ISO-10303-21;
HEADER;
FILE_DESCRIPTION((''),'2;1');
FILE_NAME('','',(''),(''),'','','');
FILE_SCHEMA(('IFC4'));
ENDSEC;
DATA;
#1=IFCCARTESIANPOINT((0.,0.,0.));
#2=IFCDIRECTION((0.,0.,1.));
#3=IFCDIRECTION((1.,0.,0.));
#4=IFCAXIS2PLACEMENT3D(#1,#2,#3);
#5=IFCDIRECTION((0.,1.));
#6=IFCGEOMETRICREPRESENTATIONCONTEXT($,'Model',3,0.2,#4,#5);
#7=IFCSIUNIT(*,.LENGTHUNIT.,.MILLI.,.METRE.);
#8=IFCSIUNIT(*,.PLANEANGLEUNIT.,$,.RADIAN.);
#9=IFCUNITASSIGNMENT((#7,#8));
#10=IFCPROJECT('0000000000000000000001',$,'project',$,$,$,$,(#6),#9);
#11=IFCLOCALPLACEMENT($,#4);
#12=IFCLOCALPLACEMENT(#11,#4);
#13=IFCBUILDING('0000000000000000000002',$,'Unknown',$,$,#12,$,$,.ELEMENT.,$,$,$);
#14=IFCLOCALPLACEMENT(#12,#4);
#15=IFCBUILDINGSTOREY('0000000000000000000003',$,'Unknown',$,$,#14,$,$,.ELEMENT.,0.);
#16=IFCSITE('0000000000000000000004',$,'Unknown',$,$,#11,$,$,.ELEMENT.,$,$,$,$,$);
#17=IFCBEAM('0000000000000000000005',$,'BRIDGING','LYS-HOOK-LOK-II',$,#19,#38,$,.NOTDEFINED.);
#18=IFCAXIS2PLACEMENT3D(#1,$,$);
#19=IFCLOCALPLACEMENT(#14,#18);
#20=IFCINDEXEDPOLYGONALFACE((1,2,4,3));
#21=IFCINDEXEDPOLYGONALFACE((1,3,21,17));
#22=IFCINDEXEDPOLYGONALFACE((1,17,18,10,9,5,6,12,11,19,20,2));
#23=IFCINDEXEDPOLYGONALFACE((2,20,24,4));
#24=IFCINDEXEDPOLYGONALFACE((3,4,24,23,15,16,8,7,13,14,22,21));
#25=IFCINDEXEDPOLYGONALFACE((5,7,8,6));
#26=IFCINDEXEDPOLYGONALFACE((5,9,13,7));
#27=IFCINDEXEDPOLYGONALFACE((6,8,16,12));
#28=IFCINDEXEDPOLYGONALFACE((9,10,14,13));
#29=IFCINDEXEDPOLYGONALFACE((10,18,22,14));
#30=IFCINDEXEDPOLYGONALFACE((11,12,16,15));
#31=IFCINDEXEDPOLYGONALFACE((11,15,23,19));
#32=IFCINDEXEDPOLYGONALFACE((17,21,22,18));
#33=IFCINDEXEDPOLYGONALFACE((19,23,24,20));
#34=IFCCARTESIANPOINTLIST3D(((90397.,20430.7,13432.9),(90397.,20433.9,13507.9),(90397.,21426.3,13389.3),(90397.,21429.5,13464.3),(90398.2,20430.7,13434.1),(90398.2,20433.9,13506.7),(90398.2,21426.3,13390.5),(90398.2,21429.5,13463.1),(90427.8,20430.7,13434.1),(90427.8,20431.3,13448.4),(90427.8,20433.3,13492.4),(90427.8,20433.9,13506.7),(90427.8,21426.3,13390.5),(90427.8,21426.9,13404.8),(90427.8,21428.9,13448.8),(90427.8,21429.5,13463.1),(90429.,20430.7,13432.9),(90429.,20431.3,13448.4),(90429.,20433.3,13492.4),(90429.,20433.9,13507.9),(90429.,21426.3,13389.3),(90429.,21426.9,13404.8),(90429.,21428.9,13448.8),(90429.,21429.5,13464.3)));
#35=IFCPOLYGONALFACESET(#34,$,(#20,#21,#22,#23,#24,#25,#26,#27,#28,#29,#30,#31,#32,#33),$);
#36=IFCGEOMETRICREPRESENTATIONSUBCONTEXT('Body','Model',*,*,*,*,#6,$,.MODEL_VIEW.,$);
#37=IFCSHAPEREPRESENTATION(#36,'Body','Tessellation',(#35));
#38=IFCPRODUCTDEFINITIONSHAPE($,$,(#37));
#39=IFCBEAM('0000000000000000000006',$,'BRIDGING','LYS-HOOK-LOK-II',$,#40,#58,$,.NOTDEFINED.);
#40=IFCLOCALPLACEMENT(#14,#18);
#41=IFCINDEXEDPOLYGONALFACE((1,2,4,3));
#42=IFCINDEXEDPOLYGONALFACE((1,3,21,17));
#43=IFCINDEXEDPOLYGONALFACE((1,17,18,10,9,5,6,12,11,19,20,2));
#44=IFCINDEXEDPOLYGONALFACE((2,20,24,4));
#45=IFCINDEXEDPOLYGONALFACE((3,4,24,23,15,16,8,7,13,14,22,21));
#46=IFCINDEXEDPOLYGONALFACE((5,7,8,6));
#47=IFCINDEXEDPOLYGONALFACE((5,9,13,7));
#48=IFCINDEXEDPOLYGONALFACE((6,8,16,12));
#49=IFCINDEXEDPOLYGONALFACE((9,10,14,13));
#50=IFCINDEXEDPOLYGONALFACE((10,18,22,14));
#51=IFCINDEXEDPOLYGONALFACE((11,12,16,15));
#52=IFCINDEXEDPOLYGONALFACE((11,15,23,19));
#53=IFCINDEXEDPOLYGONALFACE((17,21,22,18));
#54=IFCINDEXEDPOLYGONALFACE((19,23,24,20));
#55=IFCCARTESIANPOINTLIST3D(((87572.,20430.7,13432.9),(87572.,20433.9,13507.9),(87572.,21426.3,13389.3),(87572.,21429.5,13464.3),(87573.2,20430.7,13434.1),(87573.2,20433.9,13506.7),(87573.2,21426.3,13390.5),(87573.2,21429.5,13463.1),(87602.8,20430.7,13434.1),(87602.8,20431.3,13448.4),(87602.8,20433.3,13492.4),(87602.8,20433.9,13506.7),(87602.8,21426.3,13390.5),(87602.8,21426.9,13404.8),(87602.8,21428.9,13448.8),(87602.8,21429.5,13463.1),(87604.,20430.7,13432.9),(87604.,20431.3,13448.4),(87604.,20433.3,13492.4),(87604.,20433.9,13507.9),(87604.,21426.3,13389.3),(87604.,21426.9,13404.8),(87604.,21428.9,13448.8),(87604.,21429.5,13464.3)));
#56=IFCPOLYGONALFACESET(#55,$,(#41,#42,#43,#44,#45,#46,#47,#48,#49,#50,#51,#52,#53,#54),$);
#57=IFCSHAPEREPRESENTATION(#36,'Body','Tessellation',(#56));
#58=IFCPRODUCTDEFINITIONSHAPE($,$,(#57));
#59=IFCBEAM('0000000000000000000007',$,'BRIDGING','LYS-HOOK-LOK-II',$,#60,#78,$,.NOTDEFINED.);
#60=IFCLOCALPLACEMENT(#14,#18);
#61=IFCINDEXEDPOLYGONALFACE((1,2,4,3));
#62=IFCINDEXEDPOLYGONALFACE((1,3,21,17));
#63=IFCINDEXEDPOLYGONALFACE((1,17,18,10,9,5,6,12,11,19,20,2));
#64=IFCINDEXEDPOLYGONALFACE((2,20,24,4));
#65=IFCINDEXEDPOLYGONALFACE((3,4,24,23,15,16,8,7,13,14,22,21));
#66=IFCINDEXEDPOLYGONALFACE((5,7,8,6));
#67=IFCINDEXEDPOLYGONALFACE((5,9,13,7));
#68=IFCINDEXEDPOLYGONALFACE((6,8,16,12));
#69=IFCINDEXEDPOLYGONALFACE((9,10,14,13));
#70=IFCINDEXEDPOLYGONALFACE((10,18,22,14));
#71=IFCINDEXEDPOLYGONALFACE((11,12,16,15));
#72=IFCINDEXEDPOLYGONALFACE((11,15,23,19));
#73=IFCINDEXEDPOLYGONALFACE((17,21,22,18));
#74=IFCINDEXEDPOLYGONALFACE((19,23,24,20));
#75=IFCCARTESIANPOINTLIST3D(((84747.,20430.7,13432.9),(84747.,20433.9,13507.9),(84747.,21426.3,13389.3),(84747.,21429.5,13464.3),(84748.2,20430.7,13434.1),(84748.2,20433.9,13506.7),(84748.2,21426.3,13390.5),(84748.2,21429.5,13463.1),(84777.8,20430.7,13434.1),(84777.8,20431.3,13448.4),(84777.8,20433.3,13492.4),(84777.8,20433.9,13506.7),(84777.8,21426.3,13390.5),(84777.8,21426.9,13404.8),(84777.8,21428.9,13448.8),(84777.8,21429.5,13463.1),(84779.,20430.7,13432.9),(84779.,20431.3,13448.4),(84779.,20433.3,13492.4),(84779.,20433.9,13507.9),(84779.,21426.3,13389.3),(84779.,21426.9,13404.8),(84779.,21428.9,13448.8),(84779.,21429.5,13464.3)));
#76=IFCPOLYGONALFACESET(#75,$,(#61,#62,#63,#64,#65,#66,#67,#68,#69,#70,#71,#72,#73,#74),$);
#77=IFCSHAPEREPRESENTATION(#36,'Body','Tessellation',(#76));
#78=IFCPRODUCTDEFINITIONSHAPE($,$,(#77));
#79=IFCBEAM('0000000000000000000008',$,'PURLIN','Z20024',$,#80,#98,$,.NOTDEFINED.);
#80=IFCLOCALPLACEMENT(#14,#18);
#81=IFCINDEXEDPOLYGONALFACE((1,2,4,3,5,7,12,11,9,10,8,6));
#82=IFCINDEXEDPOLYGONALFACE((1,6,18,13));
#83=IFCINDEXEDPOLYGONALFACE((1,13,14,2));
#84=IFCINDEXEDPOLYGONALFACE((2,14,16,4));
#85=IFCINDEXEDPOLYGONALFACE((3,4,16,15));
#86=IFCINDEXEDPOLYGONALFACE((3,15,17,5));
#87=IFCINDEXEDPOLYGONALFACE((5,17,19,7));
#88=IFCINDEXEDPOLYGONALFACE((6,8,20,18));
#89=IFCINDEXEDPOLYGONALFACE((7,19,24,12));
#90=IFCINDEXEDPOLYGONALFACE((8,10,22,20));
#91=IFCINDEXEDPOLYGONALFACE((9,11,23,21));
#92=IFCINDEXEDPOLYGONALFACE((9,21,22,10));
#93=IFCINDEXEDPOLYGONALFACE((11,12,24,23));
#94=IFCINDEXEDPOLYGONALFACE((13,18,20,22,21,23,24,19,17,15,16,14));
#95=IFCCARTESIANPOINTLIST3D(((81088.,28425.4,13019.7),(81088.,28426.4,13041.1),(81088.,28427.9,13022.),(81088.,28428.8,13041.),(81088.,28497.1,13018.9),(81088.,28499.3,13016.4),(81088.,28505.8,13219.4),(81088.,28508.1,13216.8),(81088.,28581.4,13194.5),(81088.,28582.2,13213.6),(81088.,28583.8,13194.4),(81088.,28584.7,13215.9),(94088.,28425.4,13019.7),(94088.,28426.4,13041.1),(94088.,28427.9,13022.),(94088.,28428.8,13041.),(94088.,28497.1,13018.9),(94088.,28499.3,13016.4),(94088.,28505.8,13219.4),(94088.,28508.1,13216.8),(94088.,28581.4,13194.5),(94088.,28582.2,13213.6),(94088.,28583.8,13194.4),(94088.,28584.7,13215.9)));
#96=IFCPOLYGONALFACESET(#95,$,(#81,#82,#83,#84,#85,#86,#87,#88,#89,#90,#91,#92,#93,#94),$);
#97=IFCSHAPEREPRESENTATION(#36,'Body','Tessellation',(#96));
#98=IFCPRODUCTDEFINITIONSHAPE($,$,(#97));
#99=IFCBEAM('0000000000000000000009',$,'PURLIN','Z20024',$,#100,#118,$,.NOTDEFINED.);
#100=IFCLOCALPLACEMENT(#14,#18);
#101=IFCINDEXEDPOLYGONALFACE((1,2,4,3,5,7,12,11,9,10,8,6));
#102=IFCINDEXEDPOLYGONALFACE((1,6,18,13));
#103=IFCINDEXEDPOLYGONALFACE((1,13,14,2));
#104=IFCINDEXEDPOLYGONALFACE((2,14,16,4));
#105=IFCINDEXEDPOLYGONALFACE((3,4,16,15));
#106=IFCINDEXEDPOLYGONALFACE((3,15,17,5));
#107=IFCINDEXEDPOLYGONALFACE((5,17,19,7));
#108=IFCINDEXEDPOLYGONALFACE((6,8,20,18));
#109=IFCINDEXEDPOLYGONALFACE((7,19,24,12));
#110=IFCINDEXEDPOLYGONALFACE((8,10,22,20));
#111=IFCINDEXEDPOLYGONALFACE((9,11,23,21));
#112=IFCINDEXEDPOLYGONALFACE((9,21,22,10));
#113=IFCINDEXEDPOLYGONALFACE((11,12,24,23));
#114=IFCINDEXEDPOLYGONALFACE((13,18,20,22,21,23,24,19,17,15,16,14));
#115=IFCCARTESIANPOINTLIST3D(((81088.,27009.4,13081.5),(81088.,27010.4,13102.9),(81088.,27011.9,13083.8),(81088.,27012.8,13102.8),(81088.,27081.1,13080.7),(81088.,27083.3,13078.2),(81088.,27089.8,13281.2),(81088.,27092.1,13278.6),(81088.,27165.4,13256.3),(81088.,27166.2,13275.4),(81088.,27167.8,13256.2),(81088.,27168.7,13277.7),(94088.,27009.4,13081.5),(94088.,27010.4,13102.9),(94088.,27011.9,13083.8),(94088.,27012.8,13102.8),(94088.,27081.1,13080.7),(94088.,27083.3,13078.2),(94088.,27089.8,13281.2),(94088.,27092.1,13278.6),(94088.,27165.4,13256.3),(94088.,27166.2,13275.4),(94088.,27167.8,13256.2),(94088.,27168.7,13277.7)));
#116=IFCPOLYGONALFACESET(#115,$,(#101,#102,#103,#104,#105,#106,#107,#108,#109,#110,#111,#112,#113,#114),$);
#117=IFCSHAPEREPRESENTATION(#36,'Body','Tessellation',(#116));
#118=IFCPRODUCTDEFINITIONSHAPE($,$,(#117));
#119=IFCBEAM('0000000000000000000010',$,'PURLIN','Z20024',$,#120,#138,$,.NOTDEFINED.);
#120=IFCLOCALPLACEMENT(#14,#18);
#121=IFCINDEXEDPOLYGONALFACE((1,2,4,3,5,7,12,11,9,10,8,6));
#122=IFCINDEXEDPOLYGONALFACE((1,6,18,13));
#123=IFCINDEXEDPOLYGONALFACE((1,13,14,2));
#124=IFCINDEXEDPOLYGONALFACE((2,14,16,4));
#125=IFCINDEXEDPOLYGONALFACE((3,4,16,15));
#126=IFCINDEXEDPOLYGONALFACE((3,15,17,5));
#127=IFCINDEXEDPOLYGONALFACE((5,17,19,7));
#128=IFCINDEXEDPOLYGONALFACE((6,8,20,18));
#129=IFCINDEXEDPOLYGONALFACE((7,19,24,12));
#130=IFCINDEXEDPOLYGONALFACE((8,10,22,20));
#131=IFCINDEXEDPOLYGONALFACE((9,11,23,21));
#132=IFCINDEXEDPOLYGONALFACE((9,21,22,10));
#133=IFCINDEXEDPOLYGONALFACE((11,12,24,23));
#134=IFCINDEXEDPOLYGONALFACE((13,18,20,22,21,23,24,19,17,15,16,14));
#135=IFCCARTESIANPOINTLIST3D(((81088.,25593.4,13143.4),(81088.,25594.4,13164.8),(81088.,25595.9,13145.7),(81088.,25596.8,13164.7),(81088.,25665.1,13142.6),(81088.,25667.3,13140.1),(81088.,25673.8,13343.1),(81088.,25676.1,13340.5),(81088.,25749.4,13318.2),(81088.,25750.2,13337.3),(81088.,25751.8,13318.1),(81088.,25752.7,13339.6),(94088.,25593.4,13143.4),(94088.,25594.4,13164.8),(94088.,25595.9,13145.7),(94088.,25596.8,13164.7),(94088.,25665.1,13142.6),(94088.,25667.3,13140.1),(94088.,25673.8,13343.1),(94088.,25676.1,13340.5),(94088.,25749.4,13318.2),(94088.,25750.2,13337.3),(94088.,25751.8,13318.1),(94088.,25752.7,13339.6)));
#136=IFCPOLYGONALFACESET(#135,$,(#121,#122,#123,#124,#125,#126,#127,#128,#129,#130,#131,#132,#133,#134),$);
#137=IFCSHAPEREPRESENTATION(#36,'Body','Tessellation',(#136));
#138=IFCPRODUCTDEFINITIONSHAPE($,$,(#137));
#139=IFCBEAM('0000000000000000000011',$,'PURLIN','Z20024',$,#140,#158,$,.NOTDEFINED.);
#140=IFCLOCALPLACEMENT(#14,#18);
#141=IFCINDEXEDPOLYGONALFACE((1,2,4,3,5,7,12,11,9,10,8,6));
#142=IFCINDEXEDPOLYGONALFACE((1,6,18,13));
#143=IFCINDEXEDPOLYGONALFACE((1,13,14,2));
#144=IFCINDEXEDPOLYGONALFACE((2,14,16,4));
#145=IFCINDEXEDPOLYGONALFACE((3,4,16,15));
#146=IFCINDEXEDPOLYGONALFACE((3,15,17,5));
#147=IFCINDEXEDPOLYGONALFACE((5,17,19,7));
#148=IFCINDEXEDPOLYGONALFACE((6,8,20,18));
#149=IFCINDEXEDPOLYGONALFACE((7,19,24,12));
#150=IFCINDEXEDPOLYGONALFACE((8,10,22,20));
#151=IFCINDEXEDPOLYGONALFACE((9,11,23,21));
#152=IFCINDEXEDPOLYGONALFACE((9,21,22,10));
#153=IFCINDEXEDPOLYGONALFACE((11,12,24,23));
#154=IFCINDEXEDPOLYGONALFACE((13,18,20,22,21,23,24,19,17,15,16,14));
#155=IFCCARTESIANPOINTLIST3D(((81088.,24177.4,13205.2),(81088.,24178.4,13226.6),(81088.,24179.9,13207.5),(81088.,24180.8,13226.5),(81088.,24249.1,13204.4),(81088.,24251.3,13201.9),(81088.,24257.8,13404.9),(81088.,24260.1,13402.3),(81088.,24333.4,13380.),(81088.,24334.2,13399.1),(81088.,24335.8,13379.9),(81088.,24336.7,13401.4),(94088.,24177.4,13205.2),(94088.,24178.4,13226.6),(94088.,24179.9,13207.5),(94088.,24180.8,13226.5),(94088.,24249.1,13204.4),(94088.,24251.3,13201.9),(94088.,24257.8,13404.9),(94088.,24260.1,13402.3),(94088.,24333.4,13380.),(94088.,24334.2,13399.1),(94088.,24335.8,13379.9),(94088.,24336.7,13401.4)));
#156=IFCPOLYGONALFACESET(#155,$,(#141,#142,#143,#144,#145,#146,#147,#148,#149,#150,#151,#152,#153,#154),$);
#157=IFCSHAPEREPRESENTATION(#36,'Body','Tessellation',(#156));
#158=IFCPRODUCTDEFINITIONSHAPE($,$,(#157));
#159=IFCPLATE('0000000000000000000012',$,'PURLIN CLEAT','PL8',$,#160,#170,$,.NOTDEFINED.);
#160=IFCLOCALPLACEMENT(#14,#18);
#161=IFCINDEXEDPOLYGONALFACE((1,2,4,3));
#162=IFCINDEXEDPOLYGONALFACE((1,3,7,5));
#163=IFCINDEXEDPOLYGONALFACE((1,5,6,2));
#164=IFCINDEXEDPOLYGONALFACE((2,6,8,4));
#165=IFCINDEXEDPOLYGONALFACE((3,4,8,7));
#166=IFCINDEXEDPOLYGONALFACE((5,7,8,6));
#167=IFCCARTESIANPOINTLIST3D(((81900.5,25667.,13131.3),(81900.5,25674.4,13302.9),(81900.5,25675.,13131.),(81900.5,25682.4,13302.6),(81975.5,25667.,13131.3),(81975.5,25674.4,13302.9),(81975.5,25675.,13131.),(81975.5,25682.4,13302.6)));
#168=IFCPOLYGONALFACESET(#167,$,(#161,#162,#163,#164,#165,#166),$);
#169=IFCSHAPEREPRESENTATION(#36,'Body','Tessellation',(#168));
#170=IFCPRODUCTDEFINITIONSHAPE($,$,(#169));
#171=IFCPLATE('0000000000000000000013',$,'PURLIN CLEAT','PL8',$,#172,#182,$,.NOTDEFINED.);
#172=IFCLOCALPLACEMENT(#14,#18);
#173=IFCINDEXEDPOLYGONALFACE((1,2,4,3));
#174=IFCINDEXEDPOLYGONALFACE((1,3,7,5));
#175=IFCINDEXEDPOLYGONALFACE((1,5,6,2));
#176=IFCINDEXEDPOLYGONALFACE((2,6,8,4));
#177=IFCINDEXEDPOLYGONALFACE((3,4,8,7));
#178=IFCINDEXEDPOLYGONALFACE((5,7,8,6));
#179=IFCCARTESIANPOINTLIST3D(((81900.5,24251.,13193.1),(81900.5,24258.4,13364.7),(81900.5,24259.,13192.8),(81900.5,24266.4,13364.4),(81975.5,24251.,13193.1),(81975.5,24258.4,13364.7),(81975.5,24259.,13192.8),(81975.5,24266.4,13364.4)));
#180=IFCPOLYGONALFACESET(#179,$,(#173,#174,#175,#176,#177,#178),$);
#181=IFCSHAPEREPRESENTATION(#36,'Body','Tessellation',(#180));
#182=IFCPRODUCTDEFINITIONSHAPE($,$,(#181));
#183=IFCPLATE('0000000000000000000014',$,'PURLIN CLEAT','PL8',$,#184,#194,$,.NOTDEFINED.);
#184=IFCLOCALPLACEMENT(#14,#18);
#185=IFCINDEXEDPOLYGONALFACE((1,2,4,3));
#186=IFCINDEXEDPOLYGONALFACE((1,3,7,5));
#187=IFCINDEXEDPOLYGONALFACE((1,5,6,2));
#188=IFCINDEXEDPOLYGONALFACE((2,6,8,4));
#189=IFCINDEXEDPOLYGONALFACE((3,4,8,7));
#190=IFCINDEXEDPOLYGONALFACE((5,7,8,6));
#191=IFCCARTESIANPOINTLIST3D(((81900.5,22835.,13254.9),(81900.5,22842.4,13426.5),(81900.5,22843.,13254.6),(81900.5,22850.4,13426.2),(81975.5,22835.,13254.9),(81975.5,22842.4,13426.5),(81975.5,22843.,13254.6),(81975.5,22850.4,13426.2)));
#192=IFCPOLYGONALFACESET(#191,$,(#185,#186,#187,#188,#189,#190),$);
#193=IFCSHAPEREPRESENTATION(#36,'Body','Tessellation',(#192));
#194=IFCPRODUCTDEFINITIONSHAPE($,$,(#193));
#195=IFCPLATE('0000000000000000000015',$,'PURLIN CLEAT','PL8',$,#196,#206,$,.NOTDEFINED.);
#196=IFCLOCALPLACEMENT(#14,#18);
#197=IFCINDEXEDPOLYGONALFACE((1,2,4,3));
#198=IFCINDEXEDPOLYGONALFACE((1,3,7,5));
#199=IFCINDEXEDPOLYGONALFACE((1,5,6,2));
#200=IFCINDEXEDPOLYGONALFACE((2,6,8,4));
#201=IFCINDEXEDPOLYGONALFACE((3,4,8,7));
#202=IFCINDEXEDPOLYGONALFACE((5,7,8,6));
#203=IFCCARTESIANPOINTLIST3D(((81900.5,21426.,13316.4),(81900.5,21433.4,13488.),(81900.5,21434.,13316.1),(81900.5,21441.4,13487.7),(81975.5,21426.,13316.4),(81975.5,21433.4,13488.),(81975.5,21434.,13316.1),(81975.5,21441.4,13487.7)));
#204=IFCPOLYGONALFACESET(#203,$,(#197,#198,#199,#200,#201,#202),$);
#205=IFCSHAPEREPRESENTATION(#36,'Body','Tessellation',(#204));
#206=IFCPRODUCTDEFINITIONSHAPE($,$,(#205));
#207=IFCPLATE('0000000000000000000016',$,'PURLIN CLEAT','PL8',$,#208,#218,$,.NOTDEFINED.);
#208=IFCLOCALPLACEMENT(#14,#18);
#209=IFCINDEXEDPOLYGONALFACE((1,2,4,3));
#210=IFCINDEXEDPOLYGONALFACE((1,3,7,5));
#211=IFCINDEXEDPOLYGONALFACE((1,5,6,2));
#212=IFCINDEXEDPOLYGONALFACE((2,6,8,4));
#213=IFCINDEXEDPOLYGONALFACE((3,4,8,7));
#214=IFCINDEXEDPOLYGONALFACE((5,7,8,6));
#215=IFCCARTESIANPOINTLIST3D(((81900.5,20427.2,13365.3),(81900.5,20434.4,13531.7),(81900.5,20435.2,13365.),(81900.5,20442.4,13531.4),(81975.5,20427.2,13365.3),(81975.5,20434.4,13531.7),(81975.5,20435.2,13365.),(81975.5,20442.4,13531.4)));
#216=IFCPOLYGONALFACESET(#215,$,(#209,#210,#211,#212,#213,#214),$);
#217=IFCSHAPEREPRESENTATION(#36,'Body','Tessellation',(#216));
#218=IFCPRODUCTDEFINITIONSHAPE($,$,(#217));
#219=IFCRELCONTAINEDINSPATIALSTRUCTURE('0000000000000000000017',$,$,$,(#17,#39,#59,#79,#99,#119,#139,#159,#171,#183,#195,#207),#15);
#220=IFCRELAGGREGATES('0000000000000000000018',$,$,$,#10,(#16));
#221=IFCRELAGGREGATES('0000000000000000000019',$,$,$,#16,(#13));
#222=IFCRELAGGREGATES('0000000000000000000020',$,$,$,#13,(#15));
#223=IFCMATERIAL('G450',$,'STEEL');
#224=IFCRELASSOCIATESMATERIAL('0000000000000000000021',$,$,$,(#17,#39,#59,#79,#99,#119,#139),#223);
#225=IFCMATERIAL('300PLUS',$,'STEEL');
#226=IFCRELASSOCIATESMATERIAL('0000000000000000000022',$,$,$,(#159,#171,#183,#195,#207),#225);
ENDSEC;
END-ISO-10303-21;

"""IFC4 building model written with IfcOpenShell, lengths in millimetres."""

from ifc_helpers import new_model, si_unit, direction, frame, origin_with_axes, place, context, subcontext, project, spatial, line, indexed_curve, outline, extrude, material, element, save


model = new_model("IFC4")

# Units and contexts
model_context = context("Model", 3, precision=0.2, world=origin_with_axes(), true_north=direction((0.0, 1.0)))
body_context = subcontext(model_context, "Body", "Model", "MODEL_VIEW")
ifc_project = project(units=[si_unit("LENGTHUNIT", "METRE", prefix="MILLI"), si_unit("PLANEANGLEUNIT", "RADIAN")], contexts=[model_context])

# Site, building, storey
site_placement = place(None, origin_with_axes())
site = spatial("IfcSite", under=ifc_project, at=site_placement, Name="Unknown", CompositionType="ELEMENT")
building_placement = place(site_placement, origin_with_axes())
building = spatial("IfcBuilding", under=site, at=building_placement, Name="Unknown", CompositionType="ELEMENT")
storey_placement = place(building_placement, origin_with_axes())
storey = spatial("IfcBuildingStorey", under=building, at=storey_placement, Name="Unknown", CompositionType="ELEMENT", Elevation=0.0)

# Beams
ifc_material_1 = material(Name="G450", Category="STEEL")
for number, where, z_axis, x_axis, name in (
    (1, (90413.0, 20432.3, 13470.4), (1.0, 0.0, 0.0), (0.0, 0.999042, -0.043751), "BRIDGING"),
    (2, (87588.0, 20432.3, 13470.4), (1.0, 0.0, 0.0), (0.0, 0.999042, -0.043751), "BRIDGING"),
    (3, (84763.0, 20432.3, 13470.4), (1.0, 0.0, 0.0), (0.0, 0.999042, -0.043751), "BRIDGING"),
):
    element("IfcBeam", number, at=place(storey_placement, frame(where, z_axis=z_axis, x_axis=x_axis)), inside=storey, material=ifc_material_1, Name=name, Description="LYS-HOOK-LOK-II", PredefinedType="NOTDEFINED", context=body_context, shape_type="SolidModel", body=[
        extrude(outline(indexed_curve([(16.0, -37.5), (16.0, -22.0), (14.8, -22.0), (14.8, -36.3), (-14.8, -36.3), (-14.8, 36.3), (14.8, 36.3), (14.8, 22.0), (16.0, 22.0), (16.0, 37.5), (-16.0, 37.5), (-16.0, -37.5)], segments=[line(1, 2, 3, 4, 5, 6, 7, 8, 9, 10, 11, 12, 1)])), frame((0.0, 0.0, 0.0), z_axis=(-1.0, 0.0, 0.0), x_axis=(0.0, 0.0, 1.0)), (0.0, 0.0, -1.0), 996.6),
    ])
for number, where, z_axis, x_axis, name in (
    (4, (81088.0, 28502.6, 13117.9), (0.0, -0.999048, 0.043619), (1.0, 0.0, 0.0), "PURLIN"),
    (5, (81088.0, 27086.6, 13179.7), (0.0, -0.999048, 0.043619), (1.0, 0.0, 0.0), "PURLIN"),
    (6, (81088.0, 25670.6, 13241.6), (0.0, -0.999048, 0.043619), (1.0, 0.0, 0.0), "PURLIN"),
    (7, (81088.0, 24254.6, 13303.4), (0.0, -0.999048, 0.043619), (1.0, 0.0, 0.0), "PURLIN"),
):
    element("IfcBeam", number, at=place(storey_placement, frame(where, z_axis=z_axis, x_axis=x_axis)), inside=storey, material=ifc_material_1, Name=name, Description="Z20024", PredefinedType="NOTDEFINED", context=body_context, shape_type="SolidModel", body=[
        extrude(outline(indexed_curve([(72.8, -101.5), (72.8, -80.0), (70.4, -80.0), (70.4, -99.1), (1.2, -99.1), (1.2, 101.5), (-77.8, 101.5), (-77.8, 80.0), (-75.4, 80.0), (-75.4, 99.1), (-1.2, 99.1), (-1.2, -101.5)], segments=[line(1, 2, 3, 4, 5, 6, 7, 8, 9, 10, 11, 12, 1)])), frame((0.0, 0.0, 0.0), z_axis=(-1.0, 0.0, 0.0), x_axis=(0.0, 0.0, 1.0)), (0.0, 0.0, -1.0), 13000.0),
    ])

# Plates
ifc_material_2 = material(Name="300PLUS", Category="STEEL")
for number, where, z_axis, x_axis, name in (
    (8, (81900.5, 25671.0, 13131.2), (0.0, -0.999071, 0.043084), (1.0, 0.0, 0.0), "PURLIN CLEAT"),
    (9, (81900.5, 24255.0, 13193.0), (0.0, -0.999071, 0.043084), (1.0, 0.0, 0.0), "PURLIN CLEAT"),
    (10, (81900.5, 22839.0, 13254.8), (0.0, -0.999071, 0.043084), (1.0, 0.0, 0.0), "PURLIN CLEAT"),
    (11, (81900.5, 21430.0, 13316.3), (0.0, -0.999071, 0.043084), (1.0, 0.0, 0.0), "PURLIN CLEAT"),
):
    element("IfcPlate", number, at=place(storey_placement, frame(where, z_axis=z_axis, x_axis=x_axis)), inside=storey, material=ifc_material_2, Name=name, Description="PL8", PredefinedType="NOTDEFINED", context=body_context, shape_type="SolidModel", body=[
        extrude(outline(indexed_curve([(0.0, 0.0), (75.0, 0.0), (75.0, 171.8), (0.0, 171.8)], segments=[line(1, 2, 3, 4, 1)])), frame((0.0, 0.0, 4.0), z_axis=(0.0, 0.0, 1.0), x_axis=(1.0, 0.0, 0.0)), (0.0, 0.0, -1.0), 8.0),
    ])
plate_1_placement = place(storey_placement, frame((81900.5, 20431.2, 13365.2), z_axis=(0.0, -0.999065, 0.043229), x_axis=(1.0, 0.0, 0.0)))
element("IfcPlate", 12, at=plate_1_placement, inside=storey, material=ifc_material_2, Name="PURLIN CLEAT", Description="PL8", PredefinedType="NOTDEFINED", context=body_context, shape_type="SolidModel", body=[
    extrude(outline(indexed_curve([(0.0, 0.0), (75.0, 0.0), (75.0, 166.6), (0.0, 166.6)], segments=[line(1, 2, 3, 4, 1)])), frame((0.0, 0.0, 4.0), z_axis=(0.0, 0.0, 1.0), x_axis=(1.0, 0.0, 0.0)), (0.0, 0.0, -1.0), 8.0),
])

save(model, "model.ifc")
